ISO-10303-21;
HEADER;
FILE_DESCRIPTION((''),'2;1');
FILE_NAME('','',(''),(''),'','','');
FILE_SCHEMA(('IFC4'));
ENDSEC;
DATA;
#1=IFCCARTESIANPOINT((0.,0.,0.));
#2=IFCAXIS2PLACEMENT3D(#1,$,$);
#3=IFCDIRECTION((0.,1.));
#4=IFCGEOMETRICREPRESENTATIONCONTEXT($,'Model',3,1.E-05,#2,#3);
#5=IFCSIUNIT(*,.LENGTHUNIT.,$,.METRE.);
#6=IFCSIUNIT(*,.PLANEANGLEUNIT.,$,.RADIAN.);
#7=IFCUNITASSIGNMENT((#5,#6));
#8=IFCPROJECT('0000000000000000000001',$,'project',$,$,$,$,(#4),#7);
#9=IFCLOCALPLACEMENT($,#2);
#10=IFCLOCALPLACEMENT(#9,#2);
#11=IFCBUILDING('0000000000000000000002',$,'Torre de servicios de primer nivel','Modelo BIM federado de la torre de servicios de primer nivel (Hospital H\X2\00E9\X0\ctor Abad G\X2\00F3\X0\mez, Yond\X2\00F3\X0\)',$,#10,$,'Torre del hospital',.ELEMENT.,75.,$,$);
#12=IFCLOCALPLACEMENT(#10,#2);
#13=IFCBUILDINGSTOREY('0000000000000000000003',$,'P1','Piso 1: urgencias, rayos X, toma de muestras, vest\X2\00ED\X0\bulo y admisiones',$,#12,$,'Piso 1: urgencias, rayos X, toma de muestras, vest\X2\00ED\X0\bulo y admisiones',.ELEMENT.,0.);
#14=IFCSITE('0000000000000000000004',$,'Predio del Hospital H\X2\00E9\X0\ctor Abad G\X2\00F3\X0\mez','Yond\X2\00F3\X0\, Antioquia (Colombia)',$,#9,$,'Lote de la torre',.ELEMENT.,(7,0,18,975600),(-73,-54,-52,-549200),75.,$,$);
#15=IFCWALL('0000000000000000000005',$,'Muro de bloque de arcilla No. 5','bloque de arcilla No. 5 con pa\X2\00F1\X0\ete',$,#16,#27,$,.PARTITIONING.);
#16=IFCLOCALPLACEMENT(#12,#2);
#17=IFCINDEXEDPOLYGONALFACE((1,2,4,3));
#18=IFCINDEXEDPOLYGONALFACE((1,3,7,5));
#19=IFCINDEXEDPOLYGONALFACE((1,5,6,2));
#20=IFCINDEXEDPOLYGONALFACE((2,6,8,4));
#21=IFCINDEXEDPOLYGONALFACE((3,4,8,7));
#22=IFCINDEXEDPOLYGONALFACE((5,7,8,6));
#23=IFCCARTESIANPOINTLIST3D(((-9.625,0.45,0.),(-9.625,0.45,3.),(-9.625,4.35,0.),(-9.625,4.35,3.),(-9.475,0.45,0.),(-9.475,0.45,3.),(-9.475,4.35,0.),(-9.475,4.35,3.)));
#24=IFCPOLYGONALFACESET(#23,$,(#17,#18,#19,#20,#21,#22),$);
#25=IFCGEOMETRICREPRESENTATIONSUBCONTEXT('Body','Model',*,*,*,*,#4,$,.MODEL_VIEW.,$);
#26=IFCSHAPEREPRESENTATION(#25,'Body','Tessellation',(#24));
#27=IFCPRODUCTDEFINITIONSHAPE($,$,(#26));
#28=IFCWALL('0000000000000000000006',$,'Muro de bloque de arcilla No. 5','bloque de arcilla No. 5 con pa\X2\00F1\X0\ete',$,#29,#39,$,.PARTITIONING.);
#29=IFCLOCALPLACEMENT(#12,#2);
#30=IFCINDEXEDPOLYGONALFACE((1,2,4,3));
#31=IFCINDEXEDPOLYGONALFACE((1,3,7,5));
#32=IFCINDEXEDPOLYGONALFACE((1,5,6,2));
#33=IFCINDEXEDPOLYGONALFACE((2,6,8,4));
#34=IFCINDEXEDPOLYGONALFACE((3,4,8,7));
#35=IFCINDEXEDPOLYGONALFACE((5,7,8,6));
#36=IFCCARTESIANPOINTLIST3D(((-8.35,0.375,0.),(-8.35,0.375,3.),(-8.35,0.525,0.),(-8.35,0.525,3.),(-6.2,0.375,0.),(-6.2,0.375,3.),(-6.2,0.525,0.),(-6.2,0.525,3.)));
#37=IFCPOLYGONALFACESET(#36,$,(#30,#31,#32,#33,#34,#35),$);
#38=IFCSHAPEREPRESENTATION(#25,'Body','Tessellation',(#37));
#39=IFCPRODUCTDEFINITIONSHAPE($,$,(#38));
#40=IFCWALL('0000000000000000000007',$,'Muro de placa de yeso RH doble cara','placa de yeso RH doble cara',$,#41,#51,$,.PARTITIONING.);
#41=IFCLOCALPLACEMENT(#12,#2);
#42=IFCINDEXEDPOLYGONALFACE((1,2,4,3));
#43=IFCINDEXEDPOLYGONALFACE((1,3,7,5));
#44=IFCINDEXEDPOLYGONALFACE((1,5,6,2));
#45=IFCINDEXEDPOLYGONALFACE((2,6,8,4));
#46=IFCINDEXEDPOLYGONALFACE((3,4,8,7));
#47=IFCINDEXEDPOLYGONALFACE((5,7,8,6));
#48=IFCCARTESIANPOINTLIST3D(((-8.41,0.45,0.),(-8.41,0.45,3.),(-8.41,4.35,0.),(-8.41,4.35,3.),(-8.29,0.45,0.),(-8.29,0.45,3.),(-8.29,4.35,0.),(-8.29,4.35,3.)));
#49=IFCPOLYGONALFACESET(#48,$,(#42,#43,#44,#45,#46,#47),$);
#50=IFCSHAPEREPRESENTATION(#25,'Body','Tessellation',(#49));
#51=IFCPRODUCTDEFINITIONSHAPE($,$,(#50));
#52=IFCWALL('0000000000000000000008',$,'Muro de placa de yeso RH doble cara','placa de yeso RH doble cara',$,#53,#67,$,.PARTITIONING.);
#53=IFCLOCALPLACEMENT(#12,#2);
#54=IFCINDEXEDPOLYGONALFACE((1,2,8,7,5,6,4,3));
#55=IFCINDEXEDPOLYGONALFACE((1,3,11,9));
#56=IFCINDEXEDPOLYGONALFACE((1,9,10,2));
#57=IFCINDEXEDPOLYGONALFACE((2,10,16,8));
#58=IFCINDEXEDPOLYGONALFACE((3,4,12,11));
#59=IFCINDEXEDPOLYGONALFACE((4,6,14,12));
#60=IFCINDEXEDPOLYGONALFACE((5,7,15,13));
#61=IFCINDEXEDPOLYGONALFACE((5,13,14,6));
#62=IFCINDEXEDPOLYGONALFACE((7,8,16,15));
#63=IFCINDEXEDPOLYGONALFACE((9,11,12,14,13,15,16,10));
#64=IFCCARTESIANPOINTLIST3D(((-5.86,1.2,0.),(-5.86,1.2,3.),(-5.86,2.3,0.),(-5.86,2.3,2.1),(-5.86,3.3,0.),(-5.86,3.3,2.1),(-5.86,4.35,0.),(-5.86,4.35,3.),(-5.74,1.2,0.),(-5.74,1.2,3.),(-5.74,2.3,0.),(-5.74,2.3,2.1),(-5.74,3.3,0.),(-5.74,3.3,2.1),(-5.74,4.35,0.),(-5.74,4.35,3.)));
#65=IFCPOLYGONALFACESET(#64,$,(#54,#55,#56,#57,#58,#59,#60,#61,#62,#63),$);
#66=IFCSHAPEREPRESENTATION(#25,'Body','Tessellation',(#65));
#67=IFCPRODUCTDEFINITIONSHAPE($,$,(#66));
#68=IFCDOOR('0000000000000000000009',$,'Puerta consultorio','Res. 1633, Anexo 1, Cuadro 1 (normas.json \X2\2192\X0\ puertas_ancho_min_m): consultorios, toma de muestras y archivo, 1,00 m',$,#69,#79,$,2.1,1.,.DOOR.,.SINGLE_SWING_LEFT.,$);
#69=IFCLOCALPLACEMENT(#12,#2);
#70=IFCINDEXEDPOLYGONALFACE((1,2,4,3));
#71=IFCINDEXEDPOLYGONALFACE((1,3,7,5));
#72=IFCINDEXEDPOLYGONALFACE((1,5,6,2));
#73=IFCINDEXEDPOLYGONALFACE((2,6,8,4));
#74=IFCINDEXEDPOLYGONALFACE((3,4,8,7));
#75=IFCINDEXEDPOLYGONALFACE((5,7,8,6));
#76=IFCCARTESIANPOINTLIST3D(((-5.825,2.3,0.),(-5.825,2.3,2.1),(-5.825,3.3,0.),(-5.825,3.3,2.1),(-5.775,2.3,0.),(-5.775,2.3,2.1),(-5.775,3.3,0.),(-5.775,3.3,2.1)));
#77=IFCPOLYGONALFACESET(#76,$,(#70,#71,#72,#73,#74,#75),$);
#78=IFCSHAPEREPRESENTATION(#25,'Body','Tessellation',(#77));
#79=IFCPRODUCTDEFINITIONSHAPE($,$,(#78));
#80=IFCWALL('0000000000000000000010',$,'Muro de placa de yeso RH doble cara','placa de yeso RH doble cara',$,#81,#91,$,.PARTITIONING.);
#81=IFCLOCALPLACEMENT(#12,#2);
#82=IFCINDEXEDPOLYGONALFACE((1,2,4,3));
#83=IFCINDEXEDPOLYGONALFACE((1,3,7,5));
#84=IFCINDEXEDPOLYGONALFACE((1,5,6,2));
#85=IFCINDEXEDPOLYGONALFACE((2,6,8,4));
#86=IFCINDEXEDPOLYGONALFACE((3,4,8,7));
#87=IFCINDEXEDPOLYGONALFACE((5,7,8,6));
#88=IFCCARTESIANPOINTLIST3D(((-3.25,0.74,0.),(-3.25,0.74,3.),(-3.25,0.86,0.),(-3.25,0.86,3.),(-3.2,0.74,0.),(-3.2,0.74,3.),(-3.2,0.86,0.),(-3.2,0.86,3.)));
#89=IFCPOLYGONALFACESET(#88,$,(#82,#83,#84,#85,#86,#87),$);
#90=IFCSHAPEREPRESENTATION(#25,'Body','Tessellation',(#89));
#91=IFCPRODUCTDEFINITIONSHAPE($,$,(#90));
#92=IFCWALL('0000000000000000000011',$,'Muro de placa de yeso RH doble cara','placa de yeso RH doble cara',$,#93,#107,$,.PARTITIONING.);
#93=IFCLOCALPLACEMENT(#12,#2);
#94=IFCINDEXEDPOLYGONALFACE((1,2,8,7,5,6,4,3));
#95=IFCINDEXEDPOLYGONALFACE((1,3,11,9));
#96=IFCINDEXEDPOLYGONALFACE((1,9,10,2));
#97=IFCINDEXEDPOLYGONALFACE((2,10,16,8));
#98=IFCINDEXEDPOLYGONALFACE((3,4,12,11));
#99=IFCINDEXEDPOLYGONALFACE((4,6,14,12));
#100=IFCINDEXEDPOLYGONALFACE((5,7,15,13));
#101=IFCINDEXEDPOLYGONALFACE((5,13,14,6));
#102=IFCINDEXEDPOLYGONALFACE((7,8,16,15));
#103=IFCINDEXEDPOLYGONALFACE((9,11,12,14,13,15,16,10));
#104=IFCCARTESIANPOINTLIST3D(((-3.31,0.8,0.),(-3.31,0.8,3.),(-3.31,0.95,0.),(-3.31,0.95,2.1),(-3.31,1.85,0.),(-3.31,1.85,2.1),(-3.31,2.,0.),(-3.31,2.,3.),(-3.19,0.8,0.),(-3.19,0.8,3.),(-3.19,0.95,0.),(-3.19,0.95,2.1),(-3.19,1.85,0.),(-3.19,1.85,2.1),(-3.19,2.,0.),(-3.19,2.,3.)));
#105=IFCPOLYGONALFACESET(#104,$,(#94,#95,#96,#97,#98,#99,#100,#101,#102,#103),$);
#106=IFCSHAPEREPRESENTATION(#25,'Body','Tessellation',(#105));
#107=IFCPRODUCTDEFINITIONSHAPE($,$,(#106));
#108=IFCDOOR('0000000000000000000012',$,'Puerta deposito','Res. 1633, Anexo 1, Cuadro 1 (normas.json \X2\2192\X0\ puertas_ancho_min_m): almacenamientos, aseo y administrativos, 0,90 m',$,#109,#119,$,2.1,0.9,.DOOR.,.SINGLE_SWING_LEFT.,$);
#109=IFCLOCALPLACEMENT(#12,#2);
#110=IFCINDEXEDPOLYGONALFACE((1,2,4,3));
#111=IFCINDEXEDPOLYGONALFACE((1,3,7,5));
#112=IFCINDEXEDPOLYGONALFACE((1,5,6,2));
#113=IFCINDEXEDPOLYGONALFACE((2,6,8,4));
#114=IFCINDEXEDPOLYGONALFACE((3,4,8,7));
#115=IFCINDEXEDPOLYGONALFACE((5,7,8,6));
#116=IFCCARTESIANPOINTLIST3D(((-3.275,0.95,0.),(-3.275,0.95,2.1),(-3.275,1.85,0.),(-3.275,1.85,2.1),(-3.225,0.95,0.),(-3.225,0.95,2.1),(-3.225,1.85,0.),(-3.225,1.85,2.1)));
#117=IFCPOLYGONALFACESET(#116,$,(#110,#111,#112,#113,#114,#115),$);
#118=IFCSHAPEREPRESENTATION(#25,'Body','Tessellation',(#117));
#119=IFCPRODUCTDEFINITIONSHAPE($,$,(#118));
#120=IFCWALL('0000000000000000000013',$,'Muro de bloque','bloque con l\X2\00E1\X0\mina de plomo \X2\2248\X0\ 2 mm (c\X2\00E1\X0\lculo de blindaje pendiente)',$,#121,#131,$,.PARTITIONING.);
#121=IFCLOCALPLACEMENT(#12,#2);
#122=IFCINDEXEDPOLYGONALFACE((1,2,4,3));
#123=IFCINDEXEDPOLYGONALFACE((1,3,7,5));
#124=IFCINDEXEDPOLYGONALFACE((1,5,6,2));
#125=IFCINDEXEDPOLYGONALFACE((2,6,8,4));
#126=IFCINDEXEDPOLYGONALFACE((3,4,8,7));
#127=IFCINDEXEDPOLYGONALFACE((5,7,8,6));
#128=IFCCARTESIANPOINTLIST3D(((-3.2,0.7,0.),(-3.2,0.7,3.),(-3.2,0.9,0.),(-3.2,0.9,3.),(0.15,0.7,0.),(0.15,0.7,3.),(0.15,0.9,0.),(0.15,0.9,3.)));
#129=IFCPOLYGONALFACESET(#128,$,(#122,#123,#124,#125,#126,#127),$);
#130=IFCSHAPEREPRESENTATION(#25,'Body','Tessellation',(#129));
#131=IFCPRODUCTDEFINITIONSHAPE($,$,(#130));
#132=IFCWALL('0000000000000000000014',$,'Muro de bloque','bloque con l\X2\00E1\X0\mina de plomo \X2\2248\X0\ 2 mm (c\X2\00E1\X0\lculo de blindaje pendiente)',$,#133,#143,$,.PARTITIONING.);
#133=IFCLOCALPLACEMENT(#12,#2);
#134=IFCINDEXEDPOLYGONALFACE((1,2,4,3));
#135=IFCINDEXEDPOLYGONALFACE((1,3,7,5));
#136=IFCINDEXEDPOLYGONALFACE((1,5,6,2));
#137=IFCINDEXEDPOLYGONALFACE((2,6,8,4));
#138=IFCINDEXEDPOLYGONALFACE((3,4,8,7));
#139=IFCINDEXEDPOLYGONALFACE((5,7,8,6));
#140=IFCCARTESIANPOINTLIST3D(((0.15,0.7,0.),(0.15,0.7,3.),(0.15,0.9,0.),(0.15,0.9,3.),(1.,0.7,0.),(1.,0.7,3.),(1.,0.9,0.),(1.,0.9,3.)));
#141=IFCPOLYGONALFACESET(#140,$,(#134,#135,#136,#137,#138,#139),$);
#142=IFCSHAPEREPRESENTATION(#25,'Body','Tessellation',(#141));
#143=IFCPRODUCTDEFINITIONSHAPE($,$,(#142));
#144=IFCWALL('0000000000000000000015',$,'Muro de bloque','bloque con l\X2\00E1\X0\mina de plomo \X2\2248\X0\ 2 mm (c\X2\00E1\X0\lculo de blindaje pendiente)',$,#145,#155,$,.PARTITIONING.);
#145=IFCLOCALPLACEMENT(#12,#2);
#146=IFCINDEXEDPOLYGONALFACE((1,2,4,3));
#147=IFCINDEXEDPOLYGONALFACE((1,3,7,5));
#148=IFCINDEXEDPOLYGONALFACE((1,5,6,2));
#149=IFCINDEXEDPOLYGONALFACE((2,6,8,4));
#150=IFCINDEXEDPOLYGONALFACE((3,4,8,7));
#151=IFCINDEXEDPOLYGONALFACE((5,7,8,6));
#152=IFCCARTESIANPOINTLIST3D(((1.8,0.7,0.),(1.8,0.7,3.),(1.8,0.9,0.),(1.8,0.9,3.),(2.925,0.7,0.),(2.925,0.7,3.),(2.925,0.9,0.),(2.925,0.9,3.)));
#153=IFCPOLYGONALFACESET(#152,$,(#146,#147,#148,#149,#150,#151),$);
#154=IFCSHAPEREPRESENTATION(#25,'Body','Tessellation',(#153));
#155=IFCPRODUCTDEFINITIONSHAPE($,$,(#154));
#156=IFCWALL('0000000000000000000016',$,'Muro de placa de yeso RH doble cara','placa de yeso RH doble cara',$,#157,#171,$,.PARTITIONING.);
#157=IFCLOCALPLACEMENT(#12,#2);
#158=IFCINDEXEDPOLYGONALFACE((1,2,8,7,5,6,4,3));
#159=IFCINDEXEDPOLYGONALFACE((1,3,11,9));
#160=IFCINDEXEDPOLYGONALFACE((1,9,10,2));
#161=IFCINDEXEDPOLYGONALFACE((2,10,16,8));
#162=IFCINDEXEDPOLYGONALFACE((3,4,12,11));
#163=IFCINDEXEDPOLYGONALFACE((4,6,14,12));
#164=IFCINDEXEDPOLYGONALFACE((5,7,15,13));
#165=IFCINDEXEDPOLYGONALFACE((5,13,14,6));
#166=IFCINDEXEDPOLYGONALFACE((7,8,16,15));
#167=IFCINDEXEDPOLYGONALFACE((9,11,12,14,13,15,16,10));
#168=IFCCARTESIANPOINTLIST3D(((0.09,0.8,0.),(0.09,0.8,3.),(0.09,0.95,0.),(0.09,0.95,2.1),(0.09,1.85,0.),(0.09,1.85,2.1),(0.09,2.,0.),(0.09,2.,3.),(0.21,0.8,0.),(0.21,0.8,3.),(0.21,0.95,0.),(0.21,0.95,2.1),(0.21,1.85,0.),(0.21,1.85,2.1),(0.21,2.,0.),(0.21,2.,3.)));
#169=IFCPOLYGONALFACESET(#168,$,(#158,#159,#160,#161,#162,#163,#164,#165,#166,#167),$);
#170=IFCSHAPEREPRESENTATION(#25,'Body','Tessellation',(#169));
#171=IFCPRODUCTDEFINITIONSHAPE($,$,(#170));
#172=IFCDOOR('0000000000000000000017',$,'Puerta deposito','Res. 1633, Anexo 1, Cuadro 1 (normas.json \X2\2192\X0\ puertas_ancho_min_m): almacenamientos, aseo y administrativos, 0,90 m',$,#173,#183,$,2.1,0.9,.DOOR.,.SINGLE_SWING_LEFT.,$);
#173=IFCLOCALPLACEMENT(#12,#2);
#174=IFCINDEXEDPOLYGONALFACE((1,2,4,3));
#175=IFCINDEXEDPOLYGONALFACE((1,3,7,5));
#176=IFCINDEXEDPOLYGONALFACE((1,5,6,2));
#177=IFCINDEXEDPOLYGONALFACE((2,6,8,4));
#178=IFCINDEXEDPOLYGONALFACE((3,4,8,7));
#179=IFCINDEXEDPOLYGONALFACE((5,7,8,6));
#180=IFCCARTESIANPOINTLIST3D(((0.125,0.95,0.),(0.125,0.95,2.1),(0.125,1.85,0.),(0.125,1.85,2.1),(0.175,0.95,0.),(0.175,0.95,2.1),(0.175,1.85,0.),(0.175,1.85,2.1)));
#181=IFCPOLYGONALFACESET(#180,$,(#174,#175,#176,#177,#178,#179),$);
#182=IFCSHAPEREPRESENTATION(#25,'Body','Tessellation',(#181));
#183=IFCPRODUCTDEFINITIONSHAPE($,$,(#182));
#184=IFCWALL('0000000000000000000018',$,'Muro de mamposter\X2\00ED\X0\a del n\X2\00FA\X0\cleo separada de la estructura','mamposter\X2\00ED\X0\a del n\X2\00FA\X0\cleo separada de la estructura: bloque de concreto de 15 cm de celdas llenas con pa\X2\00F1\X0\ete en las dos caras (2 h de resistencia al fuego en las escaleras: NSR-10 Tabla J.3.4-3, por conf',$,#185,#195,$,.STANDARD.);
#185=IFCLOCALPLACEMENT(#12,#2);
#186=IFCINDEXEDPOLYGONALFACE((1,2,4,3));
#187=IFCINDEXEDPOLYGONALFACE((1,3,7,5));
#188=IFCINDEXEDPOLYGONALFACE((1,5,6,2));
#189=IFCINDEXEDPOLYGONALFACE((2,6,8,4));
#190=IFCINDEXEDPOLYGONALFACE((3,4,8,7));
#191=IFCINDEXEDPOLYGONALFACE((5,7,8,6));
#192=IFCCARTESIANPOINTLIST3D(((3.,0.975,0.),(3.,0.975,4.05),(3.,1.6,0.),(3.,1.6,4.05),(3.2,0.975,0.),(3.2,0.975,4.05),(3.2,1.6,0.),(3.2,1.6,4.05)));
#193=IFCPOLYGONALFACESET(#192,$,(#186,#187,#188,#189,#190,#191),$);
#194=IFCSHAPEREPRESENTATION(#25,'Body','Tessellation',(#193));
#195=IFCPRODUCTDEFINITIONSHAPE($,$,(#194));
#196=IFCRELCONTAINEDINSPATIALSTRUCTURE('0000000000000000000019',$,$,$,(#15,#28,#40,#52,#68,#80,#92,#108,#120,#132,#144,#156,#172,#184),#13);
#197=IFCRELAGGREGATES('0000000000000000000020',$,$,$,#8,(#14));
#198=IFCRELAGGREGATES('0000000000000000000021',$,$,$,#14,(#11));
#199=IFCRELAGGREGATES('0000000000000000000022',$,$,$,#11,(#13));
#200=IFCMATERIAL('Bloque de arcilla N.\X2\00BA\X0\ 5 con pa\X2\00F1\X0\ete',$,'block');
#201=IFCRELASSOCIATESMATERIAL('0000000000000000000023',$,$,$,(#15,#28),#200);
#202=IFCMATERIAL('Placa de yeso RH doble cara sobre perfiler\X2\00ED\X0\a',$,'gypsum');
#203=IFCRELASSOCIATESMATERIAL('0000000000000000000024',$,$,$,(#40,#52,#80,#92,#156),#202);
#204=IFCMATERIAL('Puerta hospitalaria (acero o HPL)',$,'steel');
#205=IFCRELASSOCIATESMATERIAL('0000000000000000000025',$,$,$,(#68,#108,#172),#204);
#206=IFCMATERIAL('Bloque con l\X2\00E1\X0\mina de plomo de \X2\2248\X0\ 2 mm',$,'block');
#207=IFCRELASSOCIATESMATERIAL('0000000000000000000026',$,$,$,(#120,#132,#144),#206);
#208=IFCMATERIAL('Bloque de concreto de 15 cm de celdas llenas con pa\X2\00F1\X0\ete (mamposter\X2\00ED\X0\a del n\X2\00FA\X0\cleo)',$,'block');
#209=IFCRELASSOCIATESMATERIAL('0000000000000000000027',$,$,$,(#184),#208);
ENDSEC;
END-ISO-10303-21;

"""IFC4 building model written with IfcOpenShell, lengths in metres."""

from ifc_helpers import new_model, si_unit, direction, frame, origin, place, context, subcontext, project, spatial, rectangle, extrude, material, element, fill, save


model = new_model("IFC4")

# Units and contexts
model_context = context("Model", 3, precision=1e-05, world=origin(), true_north=direction((0.0, 1.0)))
body_context = subcontext(model_context, "Body", "Model", "MODEL_VIEW")
ifc_project = project(units=[si_unit("LENGTHUNIT", "METRE"), si_unit("PLANEANGLEUNIT", "RADIAN")], contexts=[model_context])

# Site, building, storey
site_placement = place(None, origin())
site = spatial("IfcSite", under=ifc_project, at=site_placement, Name="Predio del Hospital Héctor Abad Gómez", Description="Yondó, Antioquia (Colombia)", LongName="Lote de la torre", CompositionType="ELEMENT", RefLatitude=(7, 0, 18, 975600), RefLongitude=(-73, -54, -52, -549200), RefElevation=75.0)
building_placement = place(site_placement, origin())
building = spatial("IfcBuilding", under=site, at=building_placement, Name="Torre de servicios de primer nivel", Description="Modelo BIM federado de la torre de servicios de primer nivel (Hospital Héctor Abad Gómez, Yondó)", LongName="Torre del hospital", CompositionType="ELEMENT", ElevationOfRefHeight=75.0)
placement = place(building_placement, origin())
storey = spatial("IfcBuildingStorey", under=building, at=placement, Name="P1", Description="Piso 1: urgencias, rayos X, toma de muestras, vestíbulo y admisiones", LongName="Piso 1: urgencias, rayos X, toma de muestras, vestíbulo y admisiones", CompositionType="ELEMENT", Elevation=0.0)

# Walls
ifc_material_1 = material(Name="Bloque de arcilla N.º 5 con pañete", Category="block")
element("IfcWall", 1, at=placement, inside=storey, material=ifc_material_1, Name="Muro de bloque de arcilla No. 5", Description="bloque de arcilla No. 5 con pañete", PredefinedType="PARTITIONING", context=body_context, shape_type="SweptSolid", body=[
    extrude(rectangle(XDim=0.15, YDim=3.9), frame((-9.55, 2.4, 0.0)), (0.0, 0.0, 1.0), 3.0),
])
element("IfcWall", 2, at=placement, inside=storey, material=ifc_material_1, Name="Muro de bloque de arcilla No. 5", Description="bloque de arcilla No. 5 con pañete", PredefinedType="PARTITIONING", context=body_context, shape_type="SweptSolid", body=[
    extrude(rectangle(XDim=2.15, YDim=0.15), frame((-7.275, 0.45, 0.0)), (0.0, 0.0, 1.0), 3.0),
])
ifc_material_2 = material(Name="Placa de yeso RH doble cara sobre perfilería", Category="gypsum")
element("IfcWall", 3, at=placement, inside=storey, material=ifc_material_2, Name="Muro de placa de yeso RH doble cara", Description="placa de yeso RH doble cara", PredefinedType="PARTITIONING", context=body_context, shape_type="SweptSolid", body=[
    extrude(rectangle(XDim=0.12, YDim=3.9), frame((-8.35, 2.4, 0.0)), (0.0, 0.0, 1.0), 3.0),
])

# Wall, opening, door
wall_1 = element("IfcWall", 4, at=placement, inside=storey, material=ifc_material_2, Name="Muro de placa de yeso RH doble cara", Description="placa de yeso RH doble cara", PredefinedType="PARTITIONING", context=body_context, shape_type="SweptSolid", body=[
    extrude(rectangle(XDim=0.12, YDim=3.15), frame((-5.8, 2.775, 0.0)), (0.0, 0.0, 1.0), 3.0),
])
opening_1 = element("IfcOpeningElement", 5, at=placement, cuts=wall_1, PredefinedType="OPENING", context=body_context, shape_type="SweptSolid", body=[
    extrude(rectangle(XDim=0.22, YDim=1.0), frame((-5.8, 2.8, 0.0)), (0.0, 0.0, 1.0), 2.1),
])
ifc_material_3 = material(Name="Puerta hospitalaria (acero o HPL)", Category="steel")
door_1 = element("IfcDoor", 6, at=placement, inside=storey, material=ifc_material_3, Name="Puerta consultorio", Description="Res. 1633, Anexo 1, Cuadro 1 (normas.json → puertas_ancho_min_m): consultorios, toma de muestras y archivo, 1,00 m", OperationType="SINGLE_SWING_LEFT", OverallHeight=2.1, OverallWidth=1.0, PredefinedType="DOOR", context=body_context, shape_type="SweptSolid", body=[
    extrude(rectangle(XDim=0.05, YDim=1.0), frame((-5.8, 2.8, 0.0)), (0.0, 0.0, 1.0), 2.1),
])
fill(opening_1, door_1)

# Wall
element("IfcWall", 7, at=placement, inside=storey, material=ifc_material_2, Name="Muro de placa de yeso RH doble cara", Description="placa de yeso RH doble cara", PredefinedType="PARTITIONING", context=body_context, shape_type="SweptSolid", body=[
    extrude(rectangle(XDim=0.05, YDim=0.12), frame((-3.225, 0.8, 0.0)), (0.0, 0.0, 1.0), 3.0),
])

# Wall, opening, door
wall_2 = element("IfcWall", 8, at=placement, inside=storey, material=ifc_material_2, Name="Muro de placa de yeso RH doble cara", Description="placa de yeso RH doble cara", PredefinedType="PARTITIONING", context=body_context, shape_type="SweptSolid", body=[
    extrude(rectangle(XDim=0.12, YDim=1.2), frame((-3.25, 1.4, 0.0)), (0.0, 0.0, 1.0), 3.0),
])
opening_2 = element("IfcOpeningElement", 9, at=placement, cuts=wall_2, PredefinedType="OPENING", context=body_context, shape_type="SweptSolid", body=[
    extrude(rectangle(XDim=0.22, YDim=0.9), frame((-3.25, 1.4, 0.0)), (0.0, 0.0, 1.0), 2.1),
])
door_2 = element("IfcDoor", 10, at=placement, inside=storey, material=ifc_material_3, Name="Puerta deposito", Description="Res. 1633, Anexo 1, Cuadro 1 (normas.json → puertas_ancho_min_m): almacenamientos, aseo y administrativos, 0,90 m", OperationType="SINGLE_SWING_LEFT", OverallHeight=2.1, OverallWidth=0.9, PredefinedType="DOOR", context=body_context, shape_type="SweptSolid", body=[
    extrude(rectangle(XDim=0.05, YDim=0.9), frame((-3.25, 1.4, 0.0)), (0.0, 0.0, 1.0), 2.1),
])
fill(opening_2, door_2)

# Walls
ifc_material_4 = material(Name="Bloque con lámina de plomo de ≈ 2 mm", Category="block")
element("IfcWall", 11, at=placement, inside=storey, material=ifc_material_4, Name="Muro de bloque", Description="bloque con lámina de plomo ≈ 2 mm (cálculo de blindaje pendiente)", PredefinedType="PARTITIONING", context=body_context, shape_type="SweptSolid", body=[
    extrude(rectangle(XDim=3.35, YDim=0.2), frame((-1.525, 0.8, 0.0)), (0.0, 0.0, 1.0), 3.0),
])
element("IfcWall", 12, at=placement, inside=storey, material=ifc_material_4, Name="Muro de bloque", Description="bloque con lámina de plomo ≈ 2 mm (cálculo de blindaje pendiente)", PredefinedType="PARTITIONING", context=body_context, shape_type="SweptSolid", body=[
    extrude(rectangle(XDim=0.85, YDim=0.2), frame((0.575, 0.8, 0.0)), (0.0, 0.0, 1.0), 3.0),
])
element("IfcWall", 13, at=placement, inside=storey, material=ifc_material_4, Name="Muro de bloque", Description="bloque con lámina de plomo ≈ 2 mm (cálculo de blindaje pendiente)", PredefinedType="PARTITIONING", context=body_context, shape_type="SweptSolid", body=[
    extrude(rectangle(XDim=1.125, YDim=0.2), frame((2.3625, 0.8, 0.0)), (0.0, 0.0, 1.0), 3.0),
])

# Wall, opening, door
wall_3 = element("IfcWall", 14, at=placement, inside=storey, material=ifc_material_2, Name="Muro de placa de yeso RH doble cara", Description="placa de yeso RH doble cara", PredefinedType="PARTITIONING", context=body_context, shape_type="SweptSolid", body=[
    extrude(rectangle(XDim=0.12, YDim=1.2), frame((0.15, 1.4, 0.0)), (0.0, 0.0, 1.0), 3.0),
])
opening_3 = element("IfcOpeningElement", 15, at=placement, cuts=wall_3, PredefinedType="OPENING", context=body_context, shape_type="SweptSolid", body=[
    extrude(rectangle(XDim=0.22, YDim=0.9), frame((0.15, 1.4, 0.0)), (0.0, 0.0, 1.0), 2.1),
])
door_3 = element("IfcDoor", 16, at=placement, inside=storey, material=ifc_material_3, Name="Puerta deposito", Description="Res. 1633, Anexo 1, Cuadro 1 (normas.json → puertas_ancho_min_m): almacenamientos, aseo y administrativos, 0,90 m", OperationType="SINGLE_SWING_LEFT", OverallHeight=2.1, OverallWidth=0.9, PredefinedType="DOOR", context=body_context, shape_type="SweptSolid", body=[
    extrude(rectangle(XDim=0.05, YDim=0.9), frame((0.15, 1.4, 0.0)), (0.0, 0.0, 1.0), 2.1),
])
fill(opening_3, door_3)

# Wall
ifc_material_5 = material(Name="Bloque de concreto de 15 cm de celdas llenas con pañete (mampostería del núcleo)", Category="block")
element("IfcWall", 17, at=placement, inside=storey, material=ifc_material_5, Name="Muro de mampostería del núcleo separada de la estructura", Description="mampostería del núcleo separada de la estructura: bloque de concreto de 15 cm de celdas llenas con pañete en las dos caras (2 h de resistencia al fuego en las escaleras: NSR-10 Tabla J.3.4-3, por conf", PredefinedType="STANDARD", context=body_context, shape_type="SweptSolid", body=[
    extrude(rectangle(XDim=0.2, YDim=0.625), frame((3.1, 1.2875, 0.0)), (0.0, 0.0, 1.0), 4.05),
])

save(model, "model.ifc")
